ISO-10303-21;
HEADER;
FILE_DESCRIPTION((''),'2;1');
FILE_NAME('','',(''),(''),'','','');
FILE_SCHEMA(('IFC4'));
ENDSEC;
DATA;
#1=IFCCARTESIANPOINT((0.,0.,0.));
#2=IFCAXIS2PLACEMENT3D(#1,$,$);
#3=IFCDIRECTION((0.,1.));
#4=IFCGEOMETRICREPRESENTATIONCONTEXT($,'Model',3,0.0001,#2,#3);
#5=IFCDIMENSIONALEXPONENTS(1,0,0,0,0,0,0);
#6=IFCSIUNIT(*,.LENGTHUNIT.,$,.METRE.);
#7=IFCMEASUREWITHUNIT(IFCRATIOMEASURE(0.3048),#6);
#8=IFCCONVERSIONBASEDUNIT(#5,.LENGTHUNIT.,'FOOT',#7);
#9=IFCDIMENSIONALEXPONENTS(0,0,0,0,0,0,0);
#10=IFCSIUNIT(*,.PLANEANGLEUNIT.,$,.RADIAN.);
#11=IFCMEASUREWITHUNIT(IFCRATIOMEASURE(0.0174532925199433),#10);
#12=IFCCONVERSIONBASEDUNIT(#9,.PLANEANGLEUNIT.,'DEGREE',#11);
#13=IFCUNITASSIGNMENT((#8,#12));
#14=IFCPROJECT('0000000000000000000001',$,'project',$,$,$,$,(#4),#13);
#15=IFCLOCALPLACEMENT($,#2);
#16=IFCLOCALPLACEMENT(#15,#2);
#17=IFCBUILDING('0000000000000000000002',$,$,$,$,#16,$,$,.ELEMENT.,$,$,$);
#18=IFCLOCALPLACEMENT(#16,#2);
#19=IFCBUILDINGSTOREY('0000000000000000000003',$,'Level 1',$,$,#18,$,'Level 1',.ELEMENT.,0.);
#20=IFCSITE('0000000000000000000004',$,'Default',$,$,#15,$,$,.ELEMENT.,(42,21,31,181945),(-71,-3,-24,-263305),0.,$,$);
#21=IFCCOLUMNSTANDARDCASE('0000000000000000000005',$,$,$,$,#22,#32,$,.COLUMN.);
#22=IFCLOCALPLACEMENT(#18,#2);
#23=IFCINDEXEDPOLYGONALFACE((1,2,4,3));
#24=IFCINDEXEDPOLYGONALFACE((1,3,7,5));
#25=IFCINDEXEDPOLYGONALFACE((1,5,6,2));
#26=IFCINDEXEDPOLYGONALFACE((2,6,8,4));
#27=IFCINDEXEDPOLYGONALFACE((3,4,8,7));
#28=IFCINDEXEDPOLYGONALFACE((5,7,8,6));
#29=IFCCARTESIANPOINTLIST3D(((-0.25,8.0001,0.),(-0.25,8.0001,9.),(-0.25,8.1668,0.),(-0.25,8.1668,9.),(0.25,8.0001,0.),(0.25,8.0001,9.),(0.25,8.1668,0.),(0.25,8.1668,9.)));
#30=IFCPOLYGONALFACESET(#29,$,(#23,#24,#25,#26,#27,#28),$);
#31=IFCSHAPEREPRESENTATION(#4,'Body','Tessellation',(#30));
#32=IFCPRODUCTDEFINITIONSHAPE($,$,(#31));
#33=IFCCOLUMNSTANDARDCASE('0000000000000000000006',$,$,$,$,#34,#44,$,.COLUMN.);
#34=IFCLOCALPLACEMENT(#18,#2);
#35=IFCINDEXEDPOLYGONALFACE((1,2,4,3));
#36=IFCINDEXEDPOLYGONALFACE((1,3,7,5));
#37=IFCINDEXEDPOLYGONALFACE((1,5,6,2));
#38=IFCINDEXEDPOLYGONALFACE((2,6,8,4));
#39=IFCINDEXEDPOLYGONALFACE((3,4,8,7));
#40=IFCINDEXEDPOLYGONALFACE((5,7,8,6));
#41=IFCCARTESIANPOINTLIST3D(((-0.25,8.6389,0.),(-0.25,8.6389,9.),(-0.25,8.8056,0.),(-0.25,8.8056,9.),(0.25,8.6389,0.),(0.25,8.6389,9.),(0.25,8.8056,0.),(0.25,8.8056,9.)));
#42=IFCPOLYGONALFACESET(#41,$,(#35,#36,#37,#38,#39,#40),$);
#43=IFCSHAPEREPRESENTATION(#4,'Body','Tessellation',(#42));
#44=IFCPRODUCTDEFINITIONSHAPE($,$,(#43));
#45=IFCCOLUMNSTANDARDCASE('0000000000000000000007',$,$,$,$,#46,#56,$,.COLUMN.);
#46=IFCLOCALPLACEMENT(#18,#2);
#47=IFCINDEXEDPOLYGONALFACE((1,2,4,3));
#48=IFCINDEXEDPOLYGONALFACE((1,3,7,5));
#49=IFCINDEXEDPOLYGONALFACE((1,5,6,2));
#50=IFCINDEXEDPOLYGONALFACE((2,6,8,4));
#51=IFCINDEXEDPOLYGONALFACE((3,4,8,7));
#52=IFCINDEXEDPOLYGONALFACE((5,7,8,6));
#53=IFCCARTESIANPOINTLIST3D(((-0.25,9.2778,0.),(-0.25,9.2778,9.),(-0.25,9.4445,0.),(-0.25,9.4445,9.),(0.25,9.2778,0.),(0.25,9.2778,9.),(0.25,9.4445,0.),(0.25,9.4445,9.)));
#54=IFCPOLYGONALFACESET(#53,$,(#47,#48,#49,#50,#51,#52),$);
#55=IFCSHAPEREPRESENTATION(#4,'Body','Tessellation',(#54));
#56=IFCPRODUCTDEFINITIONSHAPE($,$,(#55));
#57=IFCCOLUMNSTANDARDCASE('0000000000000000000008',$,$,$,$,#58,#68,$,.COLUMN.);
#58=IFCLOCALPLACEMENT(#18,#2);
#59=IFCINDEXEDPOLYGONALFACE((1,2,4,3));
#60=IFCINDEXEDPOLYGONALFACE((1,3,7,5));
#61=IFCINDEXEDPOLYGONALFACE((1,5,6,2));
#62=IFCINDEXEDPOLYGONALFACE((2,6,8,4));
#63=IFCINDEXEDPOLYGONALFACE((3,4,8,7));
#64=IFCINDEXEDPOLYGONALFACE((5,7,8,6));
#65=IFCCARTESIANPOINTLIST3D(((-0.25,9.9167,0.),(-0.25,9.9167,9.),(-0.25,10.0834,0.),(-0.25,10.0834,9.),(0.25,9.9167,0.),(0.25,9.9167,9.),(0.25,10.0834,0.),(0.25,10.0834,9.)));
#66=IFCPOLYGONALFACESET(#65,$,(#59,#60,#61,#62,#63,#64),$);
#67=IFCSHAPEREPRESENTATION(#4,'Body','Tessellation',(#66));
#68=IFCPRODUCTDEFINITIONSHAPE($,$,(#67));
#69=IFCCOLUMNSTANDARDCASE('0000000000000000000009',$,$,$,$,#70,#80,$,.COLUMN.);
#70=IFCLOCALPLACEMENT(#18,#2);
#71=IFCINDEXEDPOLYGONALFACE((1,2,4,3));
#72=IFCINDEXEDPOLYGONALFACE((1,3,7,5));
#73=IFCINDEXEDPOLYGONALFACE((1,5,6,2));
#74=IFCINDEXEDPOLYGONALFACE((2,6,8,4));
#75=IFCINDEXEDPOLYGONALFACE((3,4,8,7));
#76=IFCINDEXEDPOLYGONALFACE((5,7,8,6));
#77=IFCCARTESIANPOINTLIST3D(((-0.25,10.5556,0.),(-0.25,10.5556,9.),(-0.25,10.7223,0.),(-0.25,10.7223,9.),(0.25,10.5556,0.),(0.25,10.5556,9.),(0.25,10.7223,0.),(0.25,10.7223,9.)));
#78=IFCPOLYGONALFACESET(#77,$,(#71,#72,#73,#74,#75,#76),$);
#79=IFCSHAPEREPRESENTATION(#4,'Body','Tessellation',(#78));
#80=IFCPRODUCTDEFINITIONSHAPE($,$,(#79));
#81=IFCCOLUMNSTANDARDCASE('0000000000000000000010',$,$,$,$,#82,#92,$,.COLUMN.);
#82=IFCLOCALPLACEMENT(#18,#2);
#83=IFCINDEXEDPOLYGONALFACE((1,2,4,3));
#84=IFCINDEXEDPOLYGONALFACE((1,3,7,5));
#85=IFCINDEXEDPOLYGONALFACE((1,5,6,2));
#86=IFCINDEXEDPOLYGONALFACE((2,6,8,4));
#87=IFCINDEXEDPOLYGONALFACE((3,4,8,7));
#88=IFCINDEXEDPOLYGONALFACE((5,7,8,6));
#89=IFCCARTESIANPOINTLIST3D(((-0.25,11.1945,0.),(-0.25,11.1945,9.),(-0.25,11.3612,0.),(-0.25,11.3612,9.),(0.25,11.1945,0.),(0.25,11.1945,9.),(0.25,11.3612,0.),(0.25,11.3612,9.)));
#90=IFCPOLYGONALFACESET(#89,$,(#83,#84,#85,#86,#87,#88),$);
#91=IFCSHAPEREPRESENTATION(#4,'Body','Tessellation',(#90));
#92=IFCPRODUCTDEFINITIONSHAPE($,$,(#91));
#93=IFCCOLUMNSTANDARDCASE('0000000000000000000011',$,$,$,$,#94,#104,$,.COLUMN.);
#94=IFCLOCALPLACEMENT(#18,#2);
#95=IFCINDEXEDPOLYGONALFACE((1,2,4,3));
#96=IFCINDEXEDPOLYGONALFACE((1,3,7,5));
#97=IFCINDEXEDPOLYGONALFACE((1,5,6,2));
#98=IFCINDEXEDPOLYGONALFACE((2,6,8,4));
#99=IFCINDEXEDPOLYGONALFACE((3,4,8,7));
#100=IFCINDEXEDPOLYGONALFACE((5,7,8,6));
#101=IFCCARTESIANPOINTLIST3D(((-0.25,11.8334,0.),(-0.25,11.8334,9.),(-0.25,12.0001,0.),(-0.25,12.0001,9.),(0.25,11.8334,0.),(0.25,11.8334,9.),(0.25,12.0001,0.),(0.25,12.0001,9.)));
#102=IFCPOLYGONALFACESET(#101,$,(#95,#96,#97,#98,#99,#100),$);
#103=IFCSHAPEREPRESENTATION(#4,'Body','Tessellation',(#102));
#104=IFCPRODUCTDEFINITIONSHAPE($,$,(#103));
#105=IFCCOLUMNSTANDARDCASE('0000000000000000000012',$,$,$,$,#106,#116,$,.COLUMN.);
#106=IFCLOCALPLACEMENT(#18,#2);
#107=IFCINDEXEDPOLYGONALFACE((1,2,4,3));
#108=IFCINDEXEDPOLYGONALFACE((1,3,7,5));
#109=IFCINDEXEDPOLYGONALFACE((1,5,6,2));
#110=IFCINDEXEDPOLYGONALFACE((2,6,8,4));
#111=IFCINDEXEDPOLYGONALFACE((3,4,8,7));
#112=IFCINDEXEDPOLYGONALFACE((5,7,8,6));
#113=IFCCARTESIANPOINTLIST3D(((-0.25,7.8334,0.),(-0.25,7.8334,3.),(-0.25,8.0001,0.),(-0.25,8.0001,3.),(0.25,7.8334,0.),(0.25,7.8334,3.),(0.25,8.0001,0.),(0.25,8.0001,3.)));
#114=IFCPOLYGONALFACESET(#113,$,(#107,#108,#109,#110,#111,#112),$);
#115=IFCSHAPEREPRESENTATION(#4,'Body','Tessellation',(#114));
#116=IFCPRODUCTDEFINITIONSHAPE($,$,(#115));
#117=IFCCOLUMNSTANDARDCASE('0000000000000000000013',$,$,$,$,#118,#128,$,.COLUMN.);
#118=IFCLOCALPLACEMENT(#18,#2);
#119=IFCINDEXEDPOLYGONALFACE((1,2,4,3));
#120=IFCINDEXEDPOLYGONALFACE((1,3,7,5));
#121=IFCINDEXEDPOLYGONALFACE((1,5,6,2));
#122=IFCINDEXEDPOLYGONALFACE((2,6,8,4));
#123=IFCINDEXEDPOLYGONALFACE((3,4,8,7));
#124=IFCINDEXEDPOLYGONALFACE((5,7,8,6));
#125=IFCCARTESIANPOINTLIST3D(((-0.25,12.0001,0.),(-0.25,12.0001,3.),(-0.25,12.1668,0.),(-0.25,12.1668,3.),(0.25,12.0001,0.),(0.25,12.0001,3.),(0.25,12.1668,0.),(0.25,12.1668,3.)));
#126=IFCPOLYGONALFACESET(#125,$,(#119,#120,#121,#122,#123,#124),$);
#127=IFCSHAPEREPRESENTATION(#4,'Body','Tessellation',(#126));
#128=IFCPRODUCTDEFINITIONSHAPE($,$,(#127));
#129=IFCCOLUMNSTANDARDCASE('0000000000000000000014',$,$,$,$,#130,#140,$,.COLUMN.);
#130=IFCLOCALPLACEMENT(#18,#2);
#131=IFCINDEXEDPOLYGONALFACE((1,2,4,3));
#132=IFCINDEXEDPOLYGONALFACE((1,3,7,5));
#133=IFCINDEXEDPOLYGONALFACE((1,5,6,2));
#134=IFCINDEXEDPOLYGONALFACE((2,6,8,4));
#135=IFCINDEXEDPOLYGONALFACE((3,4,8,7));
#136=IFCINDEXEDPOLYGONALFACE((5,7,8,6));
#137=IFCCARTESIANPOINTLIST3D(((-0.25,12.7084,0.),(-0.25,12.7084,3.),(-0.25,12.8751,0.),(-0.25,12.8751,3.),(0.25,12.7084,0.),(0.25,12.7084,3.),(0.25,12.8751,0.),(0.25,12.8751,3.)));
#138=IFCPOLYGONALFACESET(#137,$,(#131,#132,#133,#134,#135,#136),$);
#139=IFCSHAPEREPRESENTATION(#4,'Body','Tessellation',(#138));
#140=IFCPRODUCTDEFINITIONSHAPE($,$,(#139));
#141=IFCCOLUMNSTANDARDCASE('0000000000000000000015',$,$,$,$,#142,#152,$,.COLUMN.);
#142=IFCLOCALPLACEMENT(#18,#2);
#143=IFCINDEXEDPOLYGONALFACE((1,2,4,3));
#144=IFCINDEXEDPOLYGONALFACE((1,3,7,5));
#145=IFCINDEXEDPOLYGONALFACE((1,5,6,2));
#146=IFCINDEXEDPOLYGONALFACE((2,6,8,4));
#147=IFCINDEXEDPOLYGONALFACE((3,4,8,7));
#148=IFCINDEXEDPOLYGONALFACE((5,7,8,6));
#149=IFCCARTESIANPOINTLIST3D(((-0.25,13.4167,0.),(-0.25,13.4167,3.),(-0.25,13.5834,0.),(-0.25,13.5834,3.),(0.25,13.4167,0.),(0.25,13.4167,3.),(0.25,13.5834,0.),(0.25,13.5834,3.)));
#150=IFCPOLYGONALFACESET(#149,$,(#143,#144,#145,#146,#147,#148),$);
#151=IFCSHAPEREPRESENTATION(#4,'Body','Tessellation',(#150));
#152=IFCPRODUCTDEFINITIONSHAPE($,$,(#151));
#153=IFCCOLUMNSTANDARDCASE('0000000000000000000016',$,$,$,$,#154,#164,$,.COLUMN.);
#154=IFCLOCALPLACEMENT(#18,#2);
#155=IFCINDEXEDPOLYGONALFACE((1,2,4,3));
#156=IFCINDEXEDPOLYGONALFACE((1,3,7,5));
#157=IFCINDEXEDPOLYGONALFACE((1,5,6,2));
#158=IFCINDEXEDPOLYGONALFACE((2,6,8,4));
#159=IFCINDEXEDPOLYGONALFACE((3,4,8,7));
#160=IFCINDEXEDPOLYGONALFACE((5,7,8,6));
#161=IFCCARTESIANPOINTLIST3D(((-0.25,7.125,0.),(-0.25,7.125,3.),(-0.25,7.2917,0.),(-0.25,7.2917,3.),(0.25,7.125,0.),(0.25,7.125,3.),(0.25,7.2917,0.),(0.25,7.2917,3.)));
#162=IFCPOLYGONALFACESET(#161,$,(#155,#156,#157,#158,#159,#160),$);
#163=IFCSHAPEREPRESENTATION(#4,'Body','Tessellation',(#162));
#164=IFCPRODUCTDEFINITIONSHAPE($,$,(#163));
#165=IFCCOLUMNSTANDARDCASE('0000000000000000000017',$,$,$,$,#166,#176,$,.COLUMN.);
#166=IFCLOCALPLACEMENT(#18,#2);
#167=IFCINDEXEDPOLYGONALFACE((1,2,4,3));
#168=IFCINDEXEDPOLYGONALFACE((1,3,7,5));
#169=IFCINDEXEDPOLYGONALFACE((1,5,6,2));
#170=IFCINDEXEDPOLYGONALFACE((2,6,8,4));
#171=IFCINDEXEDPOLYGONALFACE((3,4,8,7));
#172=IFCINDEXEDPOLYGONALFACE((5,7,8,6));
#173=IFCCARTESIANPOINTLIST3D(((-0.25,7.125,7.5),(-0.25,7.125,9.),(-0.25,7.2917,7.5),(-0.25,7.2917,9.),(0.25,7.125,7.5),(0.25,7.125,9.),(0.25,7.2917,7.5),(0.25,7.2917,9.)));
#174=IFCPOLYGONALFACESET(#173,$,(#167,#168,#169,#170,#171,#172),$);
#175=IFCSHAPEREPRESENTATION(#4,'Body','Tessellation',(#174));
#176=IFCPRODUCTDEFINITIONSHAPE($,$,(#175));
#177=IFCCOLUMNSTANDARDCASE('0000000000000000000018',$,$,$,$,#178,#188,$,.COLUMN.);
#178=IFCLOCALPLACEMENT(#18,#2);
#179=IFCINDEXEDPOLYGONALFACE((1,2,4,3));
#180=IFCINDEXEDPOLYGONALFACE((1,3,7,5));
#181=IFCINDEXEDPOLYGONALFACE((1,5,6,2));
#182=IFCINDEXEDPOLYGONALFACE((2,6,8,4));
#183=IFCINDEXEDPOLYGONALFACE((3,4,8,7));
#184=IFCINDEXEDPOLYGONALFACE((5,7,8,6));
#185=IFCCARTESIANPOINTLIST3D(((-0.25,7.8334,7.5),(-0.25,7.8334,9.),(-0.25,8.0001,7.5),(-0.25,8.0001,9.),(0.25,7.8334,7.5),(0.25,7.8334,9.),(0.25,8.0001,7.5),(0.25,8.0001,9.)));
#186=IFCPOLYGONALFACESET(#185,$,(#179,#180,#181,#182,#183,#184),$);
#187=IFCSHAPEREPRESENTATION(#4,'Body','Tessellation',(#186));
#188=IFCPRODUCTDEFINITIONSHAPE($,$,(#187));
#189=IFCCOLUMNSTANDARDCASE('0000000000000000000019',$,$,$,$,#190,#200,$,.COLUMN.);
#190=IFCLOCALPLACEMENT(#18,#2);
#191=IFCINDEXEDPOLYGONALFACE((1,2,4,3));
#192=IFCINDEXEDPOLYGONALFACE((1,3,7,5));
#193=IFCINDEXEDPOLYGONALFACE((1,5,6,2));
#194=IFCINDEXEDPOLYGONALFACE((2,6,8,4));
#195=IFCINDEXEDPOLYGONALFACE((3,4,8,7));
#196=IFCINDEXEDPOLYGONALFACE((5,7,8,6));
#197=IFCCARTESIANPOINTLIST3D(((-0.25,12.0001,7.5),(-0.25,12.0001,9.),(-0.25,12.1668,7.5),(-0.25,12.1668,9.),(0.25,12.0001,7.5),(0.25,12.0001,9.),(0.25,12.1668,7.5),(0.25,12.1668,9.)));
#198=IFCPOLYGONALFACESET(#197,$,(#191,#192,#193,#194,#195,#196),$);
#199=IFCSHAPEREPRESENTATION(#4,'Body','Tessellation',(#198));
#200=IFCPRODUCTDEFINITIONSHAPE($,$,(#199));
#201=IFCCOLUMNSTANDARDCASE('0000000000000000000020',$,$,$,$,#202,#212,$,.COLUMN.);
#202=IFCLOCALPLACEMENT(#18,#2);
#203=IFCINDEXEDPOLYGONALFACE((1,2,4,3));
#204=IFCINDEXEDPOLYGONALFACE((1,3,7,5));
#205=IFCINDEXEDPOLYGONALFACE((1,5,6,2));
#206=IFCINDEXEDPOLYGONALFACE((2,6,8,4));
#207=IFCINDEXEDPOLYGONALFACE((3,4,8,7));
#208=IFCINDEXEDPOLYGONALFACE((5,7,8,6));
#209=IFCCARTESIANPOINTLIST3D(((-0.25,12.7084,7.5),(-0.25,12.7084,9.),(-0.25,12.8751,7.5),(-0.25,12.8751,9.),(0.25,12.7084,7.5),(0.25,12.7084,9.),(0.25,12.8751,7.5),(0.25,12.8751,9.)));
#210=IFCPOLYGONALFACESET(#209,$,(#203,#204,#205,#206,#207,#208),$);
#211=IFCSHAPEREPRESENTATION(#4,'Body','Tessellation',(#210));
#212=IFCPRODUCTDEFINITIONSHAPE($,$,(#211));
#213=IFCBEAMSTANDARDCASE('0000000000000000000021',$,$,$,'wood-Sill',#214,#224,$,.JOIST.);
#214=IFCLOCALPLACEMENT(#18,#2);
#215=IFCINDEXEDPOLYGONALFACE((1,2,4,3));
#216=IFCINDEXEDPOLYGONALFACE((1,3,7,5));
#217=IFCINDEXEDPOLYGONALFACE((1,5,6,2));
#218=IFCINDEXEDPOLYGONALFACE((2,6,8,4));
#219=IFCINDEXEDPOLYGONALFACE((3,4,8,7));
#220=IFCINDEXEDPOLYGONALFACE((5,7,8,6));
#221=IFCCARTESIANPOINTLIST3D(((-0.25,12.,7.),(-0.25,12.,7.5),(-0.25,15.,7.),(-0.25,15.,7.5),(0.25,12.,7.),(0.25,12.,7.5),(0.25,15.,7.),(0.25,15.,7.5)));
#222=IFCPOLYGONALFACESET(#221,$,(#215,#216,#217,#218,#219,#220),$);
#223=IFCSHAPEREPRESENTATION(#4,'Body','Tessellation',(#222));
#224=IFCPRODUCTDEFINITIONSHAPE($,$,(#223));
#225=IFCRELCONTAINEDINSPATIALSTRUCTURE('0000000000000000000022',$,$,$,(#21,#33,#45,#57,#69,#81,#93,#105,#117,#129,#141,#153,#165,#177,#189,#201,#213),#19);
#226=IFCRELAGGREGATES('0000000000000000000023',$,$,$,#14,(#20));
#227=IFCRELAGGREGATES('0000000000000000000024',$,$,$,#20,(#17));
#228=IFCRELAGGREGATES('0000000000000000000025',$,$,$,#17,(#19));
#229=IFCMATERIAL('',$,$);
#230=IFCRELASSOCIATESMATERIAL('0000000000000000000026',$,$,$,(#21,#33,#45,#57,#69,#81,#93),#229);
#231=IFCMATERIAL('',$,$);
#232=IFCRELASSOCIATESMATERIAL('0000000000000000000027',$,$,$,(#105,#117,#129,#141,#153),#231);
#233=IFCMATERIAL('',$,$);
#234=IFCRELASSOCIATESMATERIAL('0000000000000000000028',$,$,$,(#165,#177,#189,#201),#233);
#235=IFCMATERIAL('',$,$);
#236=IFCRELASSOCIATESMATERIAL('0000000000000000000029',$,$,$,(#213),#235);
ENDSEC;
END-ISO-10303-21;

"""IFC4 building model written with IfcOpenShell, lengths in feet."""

from ifc_helpers import new_model, entity, si_unit, converted_unit, direction, frame, origin, place, context, project, spatial, rectangle, extrude, material, element, save


model = new_model("IFC4")

# Units and contexts
model_context = context("Model", 3, precision=0.0001, world=origin(), true_north=direction((0.0, 1.0)))
ifc_project = project(units=[converted_unit("LENGTHUNIT", "FOOT", entity("IfcRatioMeasure", 0.3048), si_unit("LENGTHUNIT", "METRE"), dimensions=[1, 0, 0, 0, 0, 0, 0]), converted_unit("PLANEANGLEUNIT", "DEGREE", entity("IfcRatioMeasure", 0.0174532925199433), si_unit("PLANEANGLEUNIT", "RADIAN"), dimensions=[0, 0, 0, 0, 0, 0, 0])], contexts=[model_context])

# Site, building, storey
site_placement = place(None, origin())
site = spatial("IfcSite", under=ifc_project, at=site_placement, Name="Default", CompositionType="ELEMENT", RefLatitude=(42, 21, 31, 181945), RefLongitude=(-71, -3, -24, -263305), RefElevation=0.0)
building_placement = place(site_placement, origin())
building = spatial("IfcBuilding", under=site, at=building_placement, CompositionType="ELEMENT")
storey_placement = place(building_placement, origin())
storey = spatial("IfcBuildingStorey", under=building, at=storey_placement, Name="Level 1", LongName="Level 1", CompositionType="ELEMENT", Elevation=0.0)

# Columns
ifc_material_1 = material(Name="")
placement = place(storey_placement, frame((0.0, -0.25, 0.0), z_axis=(0.0, 0.0, 1.0), x_axis=(0.0, 1.0, 0.0)))
for number, where, z_axis, x_axis in (
    (1, (8.3334, 0.0, 0.0), (0.0, 0.0, 1.0), (1.0, 0.0, 0.0)),
    (2, (8.9722, 0.0, 0.0), (0.0, 0.0, 1.0), (1.0, 0.0, 0.0)),
    (3, (9.6111, 0.0, 0.0), (0.0, 0.0, 1.0), (1.0, 0.0, 0.0)),
    (4, (10.25, 0.0, 0.0), (0.0, 0.0, 1.0), (1.0, 0.0, 0.0)),
    (5, (10.8889, 0.0, 0.0), (0.0, 0.0, 1.0), (1.0, 0.0, 0.0)),
    (6, (11.5278, 0.0, 0.0), (0.0, 0.0, 1.0), (1.0, 0.0, 0.0)),
    (7, (12.1667, 0.0, 0.0), (0.0, 0.0, 1.0), (1.0, 0.0, 0.0)),
):
    element("IfcColumnStandardCase", number, at=place(placement, frame(where, z_axis=z_axis, x_axis=x_axis)), inside=storey, material=ifc_material_1, PredefinedType="COLUMN", context=model_context, shape_type="SweptSolid", body=[
        extrude(rectangle(XDim=0.1667, YDim=0.5), origin(), (0.0, 0.0, 1.0), 9.0),
    ])
ifc_material_2 = material(Name="")
for number, where, z_axis, x_axis in (
    (8, (8.1667, 0.0, 0.0), (0.0, 0.0, 1.0), (1.0, 0.0, 0.0)),
    (9, (12.3334, 0.0, 0.0), (0.0, 0.0, 1.0), (1.0, 0.0, 0.0)),
    (10, (13.0417, 0.0, 0.0), (0.0, 0.0, 1.0), (1.0, 0.0, 0.0)),
    (11, (13.75, 0.0, 0.0), (0.0, 0.0, 1.0), (1.0, 0.0, 0.0)),
    (12, (7.4583, 0.0, 0.0), (0.0, 0.0, 1.0), (1.0, 0.0, 0.0)),
):
    element("IfcColumnStandardCase", number, at=place(placement, frame(where, z_axis=z_axis, x_axis=x_axis)), inside=storey, material=ifc_material_2, PredefinedType="COLUMN", context=model_context, shape_type="SweptSolid", body=[
        extrude(rectangle(XDim=0.1667, YDim=0.5), origin(), (0.0, 0.0, 1.0), 3.0),
    ])
ifc_material_3 = material(Name="")
for number, where, z_axis, x_axis in (
    (13, (7.4583, 0.0, 7.5), (0.0, 0.0, 1.0), (1.0, 0.0, 0.0)),
    (14, (8.1667, 0.0, 7.5), (0.0, 0.0, 1.0), (1.0, 0.0, 0.0)),
    (15, (12.3334, 0.0, 7.5), (0.0, 0.0, 1.0), (1.0, 0.0, 0.0)),
    (16, (13.0417, 0.0, 7.5), (0.0, 0.0, 1.0), (1.0, 0.0, 0.0)),
):
    element("IfcColumnStandardCase", number, at=place(placement, frame(where, z_axis=z_axis, x_axis=x_axis)), inside=storey, material=ifc_material_3, PredefinedType="COLUMN", context=model_context, shape_type="SweptSolid", body=[
        extrude(rectangle(XDim=0.1667, YDim=0.5), origin(), (0.0, 0.0, 1.0), 1.5),
    ])

# Beam
ifc_material_4 = material(Name="")
for number, where, z_axis, x_axis in (
    (17, (13.75, 0.0, 7.0), (0.0, 0.0, 1.0), (-1.0, 0.0, 0.0)),
):
    element("IfcBeamStandardCase", number, at=place(placement, frame(where, z_axis=z_axis, x_axis=x_axis)), inside=storey, material=ifc_material_4, ObjectType="wood-Sill", PredefinedType="JOIST", context=model_context, shape_type="SweptSolid", body=[
        extrude(rectangle(XDim=3.0, YDim=0.5), origin(), (0.0, 0.0, 1.0), 0.5),
    ])

save(model, "model.ifc")
